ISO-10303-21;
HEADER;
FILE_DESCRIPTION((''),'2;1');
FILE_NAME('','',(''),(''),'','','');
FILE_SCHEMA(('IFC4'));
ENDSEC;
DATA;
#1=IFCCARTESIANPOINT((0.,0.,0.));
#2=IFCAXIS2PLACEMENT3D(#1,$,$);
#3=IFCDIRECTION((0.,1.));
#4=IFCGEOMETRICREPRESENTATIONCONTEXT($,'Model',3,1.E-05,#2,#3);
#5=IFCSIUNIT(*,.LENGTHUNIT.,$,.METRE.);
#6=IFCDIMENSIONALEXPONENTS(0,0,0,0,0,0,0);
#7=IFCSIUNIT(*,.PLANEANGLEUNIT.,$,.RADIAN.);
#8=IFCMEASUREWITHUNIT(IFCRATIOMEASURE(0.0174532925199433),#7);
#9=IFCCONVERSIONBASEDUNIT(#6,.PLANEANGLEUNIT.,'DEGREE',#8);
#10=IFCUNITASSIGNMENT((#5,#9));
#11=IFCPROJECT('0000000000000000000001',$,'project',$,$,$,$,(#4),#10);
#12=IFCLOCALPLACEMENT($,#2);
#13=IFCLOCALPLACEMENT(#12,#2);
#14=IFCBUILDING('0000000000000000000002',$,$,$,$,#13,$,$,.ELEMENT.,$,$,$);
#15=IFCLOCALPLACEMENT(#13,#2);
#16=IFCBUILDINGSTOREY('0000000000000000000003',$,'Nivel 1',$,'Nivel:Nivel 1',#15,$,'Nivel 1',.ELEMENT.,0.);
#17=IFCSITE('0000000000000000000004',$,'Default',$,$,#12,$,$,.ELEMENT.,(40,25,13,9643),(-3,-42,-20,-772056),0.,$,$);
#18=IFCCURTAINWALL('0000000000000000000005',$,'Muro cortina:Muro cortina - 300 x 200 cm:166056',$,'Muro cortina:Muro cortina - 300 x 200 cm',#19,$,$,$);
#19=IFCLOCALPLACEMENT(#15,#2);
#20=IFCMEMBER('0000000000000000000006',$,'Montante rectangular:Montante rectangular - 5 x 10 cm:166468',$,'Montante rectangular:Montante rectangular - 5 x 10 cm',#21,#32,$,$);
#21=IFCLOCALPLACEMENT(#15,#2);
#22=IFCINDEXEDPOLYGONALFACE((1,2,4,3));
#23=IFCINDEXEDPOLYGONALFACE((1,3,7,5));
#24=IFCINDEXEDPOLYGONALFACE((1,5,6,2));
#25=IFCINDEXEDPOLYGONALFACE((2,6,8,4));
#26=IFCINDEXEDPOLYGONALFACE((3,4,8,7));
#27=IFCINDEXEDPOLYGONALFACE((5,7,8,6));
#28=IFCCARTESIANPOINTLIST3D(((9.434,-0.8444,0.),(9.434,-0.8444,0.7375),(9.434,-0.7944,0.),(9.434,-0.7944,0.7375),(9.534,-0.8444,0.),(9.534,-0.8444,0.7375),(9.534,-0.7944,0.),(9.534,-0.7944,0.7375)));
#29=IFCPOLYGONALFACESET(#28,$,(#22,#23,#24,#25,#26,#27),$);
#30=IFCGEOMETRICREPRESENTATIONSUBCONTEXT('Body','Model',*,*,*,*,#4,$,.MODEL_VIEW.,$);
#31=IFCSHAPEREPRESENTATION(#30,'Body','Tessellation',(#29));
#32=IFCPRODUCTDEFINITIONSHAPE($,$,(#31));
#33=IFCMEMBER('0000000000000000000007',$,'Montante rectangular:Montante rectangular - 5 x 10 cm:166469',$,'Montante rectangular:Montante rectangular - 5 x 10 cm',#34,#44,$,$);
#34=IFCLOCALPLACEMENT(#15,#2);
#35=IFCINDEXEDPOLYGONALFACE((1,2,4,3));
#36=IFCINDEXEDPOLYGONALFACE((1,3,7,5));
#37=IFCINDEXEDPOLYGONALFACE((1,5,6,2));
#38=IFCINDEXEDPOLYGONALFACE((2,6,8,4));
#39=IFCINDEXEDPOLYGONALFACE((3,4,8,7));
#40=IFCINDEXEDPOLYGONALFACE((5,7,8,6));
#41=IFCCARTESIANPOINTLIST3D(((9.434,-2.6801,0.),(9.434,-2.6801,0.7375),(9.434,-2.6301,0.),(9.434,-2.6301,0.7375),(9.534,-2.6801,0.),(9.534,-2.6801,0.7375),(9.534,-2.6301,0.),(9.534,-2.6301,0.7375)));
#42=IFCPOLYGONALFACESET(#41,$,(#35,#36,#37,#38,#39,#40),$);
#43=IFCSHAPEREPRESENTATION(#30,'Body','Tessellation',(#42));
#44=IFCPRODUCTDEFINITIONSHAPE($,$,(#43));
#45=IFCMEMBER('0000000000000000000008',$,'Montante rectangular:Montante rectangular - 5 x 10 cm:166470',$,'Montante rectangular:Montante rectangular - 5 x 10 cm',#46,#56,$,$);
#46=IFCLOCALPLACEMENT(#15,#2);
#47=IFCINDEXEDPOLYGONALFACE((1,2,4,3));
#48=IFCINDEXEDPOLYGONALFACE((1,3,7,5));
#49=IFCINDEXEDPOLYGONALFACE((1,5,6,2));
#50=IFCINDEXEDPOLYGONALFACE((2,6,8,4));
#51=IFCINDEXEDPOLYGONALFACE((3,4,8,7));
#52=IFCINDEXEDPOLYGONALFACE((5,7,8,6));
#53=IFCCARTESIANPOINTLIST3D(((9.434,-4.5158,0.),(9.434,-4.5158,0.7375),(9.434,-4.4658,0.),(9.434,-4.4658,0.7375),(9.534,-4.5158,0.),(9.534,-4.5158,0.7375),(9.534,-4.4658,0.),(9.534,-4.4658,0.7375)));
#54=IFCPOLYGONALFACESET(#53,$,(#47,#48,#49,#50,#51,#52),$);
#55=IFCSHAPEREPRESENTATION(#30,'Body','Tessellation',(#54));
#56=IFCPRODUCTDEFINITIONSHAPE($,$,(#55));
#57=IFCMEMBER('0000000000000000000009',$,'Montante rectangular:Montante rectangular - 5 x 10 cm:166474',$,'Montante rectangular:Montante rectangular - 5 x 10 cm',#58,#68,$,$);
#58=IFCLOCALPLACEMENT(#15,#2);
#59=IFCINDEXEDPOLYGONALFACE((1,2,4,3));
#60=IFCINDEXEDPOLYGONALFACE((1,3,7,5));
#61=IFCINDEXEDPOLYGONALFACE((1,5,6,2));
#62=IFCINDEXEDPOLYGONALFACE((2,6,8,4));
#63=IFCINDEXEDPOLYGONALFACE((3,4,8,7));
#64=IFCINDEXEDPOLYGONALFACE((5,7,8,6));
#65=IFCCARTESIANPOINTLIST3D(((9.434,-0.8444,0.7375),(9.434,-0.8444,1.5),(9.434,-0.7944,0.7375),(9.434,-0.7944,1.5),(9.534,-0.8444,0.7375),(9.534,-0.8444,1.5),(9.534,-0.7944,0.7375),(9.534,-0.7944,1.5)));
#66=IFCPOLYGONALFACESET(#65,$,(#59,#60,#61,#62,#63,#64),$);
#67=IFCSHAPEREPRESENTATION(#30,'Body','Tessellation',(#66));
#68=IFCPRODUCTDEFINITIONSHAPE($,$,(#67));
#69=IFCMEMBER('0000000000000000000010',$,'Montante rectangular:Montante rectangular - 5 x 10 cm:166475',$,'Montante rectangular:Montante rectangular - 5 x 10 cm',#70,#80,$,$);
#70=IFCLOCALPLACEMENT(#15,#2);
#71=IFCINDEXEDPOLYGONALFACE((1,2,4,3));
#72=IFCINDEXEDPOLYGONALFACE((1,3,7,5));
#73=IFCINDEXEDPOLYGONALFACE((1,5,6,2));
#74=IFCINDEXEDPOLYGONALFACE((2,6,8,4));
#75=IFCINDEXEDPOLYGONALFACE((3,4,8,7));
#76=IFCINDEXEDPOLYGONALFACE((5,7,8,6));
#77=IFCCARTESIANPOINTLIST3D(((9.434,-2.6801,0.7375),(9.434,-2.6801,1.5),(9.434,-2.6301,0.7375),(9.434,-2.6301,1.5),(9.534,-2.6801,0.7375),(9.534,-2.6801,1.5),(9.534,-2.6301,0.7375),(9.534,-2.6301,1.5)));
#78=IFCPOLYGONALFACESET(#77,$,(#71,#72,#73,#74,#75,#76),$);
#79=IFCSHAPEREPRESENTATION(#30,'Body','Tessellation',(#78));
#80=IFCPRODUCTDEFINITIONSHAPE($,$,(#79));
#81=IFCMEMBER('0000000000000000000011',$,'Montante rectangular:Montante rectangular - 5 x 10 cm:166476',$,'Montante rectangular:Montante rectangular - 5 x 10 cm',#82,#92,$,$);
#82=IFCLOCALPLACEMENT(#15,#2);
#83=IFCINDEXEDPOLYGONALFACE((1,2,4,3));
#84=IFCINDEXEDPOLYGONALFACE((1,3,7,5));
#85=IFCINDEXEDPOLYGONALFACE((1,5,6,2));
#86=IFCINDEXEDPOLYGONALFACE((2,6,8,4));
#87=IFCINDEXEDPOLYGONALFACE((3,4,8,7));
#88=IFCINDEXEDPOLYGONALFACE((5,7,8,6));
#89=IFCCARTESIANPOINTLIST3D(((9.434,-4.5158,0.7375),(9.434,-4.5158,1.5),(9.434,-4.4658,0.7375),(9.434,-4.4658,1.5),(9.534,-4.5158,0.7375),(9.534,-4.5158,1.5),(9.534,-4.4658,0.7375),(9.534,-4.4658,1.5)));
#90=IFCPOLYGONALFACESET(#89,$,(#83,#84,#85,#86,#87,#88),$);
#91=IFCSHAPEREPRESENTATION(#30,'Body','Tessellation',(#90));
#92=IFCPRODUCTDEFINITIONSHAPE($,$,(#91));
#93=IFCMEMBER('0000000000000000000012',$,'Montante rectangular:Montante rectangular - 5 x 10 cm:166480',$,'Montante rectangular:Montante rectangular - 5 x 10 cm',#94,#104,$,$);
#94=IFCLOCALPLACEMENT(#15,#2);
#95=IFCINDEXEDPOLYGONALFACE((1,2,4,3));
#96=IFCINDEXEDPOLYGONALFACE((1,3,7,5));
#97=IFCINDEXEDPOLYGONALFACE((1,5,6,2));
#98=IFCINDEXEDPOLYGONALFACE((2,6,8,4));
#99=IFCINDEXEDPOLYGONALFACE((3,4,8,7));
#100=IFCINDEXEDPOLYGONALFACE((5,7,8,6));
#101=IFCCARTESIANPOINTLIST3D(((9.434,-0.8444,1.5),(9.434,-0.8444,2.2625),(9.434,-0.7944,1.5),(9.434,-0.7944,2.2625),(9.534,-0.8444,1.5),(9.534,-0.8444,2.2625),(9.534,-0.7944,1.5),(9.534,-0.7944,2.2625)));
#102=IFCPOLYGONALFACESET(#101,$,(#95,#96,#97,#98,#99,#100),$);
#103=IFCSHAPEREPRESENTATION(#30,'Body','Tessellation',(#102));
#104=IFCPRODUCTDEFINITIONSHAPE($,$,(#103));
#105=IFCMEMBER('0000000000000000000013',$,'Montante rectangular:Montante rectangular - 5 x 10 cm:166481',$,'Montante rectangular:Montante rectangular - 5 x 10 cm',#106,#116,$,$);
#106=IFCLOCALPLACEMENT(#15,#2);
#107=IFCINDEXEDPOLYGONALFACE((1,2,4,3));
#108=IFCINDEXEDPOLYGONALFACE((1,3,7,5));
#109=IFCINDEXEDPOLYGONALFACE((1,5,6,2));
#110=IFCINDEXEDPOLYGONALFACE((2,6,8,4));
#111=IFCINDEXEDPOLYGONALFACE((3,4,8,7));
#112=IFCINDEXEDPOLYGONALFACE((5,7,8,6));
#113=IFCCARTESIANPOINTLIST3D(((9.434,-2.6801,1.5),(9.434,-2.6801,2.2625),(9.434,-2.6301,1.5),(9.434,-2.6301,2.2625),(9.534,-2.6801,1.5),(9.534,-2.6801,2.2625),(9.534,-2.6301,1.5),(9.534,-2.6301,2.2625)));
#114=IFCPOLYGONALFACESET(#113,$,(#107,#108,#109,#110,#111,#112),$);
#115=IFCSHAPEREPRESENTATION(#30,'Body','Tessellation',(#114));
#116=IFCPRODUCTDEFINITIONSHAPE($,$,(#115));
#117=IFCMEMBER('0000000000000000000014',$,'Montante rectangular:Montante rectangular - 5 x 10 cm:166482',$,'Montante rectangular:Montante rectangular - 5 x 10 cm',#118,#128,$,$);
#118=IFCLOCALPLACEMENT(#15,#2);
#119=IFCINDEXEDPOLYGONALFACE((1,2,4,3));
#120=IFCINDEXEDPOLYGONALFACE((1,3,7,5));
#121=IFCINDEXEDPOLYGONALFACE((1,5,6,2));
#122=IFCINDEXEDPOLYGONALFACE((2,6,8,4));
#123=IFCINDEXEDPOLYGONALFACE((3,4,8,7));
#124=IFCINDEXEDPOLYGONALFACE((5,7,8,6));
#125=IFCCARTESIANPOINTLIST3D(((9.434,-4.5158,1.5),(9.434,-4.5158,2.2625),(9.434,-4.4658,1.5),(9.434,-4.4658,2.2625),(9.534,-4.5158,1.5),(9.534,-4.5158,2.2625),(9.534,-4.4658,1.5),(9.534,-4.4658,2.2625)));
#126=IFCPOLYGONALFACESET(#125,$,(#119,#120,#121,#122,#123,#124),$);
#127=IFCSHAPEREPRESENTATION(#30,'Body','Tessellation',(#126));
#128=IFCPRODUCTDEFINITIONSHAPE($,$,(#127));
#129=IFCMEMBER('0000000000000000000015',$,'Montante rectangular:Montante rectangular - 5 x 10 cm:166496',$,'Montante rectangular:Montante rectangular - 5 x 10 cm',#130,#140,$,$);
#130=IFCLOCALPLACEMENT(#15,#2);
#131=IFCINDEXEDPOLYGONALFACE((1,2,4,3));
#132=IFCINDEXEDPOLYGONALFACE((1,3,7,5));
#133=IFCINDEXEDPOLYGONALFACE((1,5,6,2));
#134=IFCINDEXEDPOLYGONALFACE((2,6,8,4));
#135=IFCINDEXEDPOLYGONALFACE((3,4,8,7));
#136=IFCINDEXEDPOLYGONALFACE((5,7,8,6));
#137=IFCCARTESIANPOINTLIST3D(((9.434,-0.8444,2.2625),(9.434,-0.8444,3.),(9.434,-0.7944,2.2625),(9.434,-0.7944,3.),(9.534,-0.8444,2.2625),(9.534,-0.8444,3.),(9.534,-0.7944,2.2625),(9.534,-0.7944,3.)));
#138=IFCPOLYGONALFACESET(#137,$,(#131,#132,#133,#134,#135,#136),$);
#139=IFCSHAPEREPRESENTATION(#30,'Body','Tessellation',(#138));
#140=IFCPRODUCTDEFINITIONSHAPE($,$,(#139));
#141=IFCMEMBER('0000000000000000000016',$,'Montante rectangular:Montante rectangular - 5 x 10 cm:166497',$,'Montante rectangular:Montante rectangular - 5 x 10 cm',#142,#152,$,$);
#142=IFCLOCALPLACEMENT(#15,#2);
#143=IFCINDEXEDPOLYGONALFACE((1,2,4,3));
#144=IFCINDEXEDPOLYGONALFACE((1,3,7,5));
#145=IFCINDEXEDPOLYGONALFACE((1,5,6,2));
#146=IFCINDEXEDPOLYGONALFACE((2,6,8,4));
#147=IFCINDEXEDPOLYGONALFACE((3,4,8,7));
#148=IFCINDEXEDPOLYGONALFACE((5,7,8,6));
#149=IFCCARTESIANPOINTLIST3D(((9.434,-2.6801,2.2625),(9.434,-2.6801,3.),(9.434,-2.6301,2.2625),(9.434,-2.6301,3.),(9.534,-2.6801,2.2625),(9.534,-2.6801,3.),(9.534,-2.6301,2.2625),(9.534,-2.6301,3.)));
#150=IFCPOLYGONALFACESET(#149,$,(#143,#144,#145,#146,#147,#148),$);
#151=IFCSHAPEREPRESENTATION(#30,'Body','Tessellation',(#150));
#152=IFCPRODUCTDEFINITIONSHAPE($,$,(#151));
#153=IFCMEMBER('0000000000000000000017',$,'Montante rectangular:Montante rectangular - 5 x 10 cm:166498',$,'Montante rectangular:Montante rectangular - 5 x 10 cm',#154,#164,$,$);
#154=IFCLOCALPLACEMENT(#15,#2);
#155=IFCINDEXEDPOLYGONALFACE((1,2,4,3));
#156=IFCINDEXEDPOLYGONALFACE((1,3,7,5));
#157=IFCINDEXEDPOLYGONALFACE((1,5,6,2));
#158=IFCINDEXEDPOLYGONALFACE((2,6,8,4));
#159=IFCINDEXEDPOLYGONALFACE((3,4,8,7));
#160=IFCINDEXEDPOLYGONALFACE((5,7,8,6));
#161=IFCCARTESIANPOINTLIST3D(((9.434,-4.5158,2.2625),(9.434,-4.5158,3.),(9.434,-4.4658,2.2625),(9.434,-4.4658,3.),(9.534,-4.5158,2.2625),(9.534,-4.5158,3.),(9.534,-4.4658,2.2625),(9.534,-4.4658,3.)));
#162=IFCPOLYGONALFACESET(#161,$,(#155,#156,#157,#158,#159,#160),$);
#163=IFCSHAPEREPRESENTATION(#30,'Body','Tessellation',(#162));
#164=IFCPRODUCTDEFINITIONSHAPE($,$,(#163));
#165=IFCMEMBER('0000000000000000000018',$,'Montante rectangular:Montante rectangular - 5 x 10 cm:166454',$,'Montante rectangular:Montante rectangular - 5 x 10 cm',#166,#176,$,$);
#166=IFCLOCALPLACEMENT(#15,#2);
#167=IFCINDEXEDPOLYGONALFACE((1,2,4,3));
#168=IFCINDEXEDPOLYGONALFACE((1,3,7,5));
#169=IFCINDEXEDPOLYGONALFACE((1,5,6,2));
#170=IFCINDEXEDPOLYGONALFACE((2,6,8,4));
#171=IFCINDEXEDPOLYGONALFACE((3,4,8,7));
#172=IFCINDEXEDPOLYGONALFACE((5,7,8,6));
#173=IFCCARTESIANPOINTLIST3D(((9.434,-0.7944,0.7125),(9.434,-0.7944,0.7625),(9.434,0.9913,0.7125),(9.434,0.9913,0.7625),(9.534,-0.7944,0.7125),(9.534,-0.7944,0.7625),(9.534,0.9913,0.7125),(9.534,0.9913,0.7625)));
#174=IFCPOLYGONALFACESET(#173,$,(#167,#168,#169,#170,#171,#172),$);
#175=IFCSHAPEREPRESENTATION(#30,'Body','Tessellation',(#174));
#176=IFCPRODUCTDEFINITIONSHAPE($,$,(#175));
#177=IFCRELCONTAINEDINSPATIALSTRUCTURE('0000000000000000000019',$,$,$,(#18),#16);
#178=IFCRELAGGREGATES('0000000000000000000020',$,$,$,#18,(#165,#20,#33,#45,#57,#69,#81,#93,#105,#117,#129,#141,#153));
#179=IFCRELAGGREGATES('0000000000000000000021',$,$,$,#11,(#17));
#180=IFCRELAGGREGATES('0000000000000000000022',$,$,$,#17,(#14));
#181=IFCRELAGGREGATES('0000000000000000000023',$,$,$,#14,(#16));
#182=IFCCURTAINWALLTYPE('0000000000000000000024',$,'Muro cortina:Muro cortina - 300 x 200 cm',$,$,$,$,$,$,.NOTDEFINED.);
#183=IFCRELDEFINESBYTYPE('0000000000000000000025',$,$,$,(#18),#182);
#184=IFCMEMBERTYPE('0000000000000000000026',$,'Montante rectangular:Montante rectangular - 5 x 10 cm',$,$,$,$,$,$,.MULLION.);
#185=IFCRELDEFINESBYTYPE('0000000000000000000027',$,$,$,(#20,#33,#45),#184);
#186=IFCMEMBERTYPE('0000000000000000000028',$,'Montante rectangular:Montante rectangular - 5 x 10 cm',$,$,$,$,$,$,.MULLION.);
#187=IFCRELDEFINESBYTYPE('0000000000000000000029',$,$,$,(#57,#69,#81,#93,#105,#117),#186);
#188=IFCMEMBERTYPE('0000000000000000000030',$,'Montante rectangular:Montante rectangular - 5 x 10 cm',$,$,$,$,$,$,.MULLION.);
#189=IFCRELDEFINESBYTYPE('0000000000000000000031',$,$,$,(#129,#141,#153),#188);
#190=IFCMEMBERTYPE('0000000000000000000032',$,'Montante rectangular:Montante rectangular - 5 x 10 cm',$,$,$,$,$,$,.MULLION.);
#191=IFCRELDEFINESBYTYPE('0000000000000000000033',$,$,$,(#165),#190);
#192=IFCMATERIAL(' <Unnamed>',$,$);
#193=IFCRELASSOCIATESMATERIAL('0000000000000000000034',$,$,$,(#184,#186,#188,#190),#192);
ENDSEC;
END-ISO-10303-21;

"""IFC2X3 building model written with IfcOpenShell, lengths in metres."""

from ifc_helpers import new_model, entity, si_unit, converted_unit, direction, frame, origin, origin_2d_with_axis, place, context, subcontext, project, spatial, rectangle, extrude, source, transform, mapped, material, type_object, type_shapes, element, aggregate, save


model = new_model("IFC2X3")

# Units and contexts
model_context = context("Model", 3, precision=1e-05, world=origin(), true_north=direction((0.0, 1.0)))
body_context = subcontext(model_context, "Body", "Model", "MODEL_VIEW")
ifc_project = project(units=[si_unit("LENGTHUNIT", "METRE"), converted_unit("PLANEANGLEUNIT", "DEGREE", entity("IfcRatioMeasure", 0.0174532925199433), si_unit("PLANEANGLEUNIT", "RADIAN"), dimensions=[0, 0, 0, 0, 0, 0, 0])], contexts=[model_context])

# Site, building, storey
site_placement = place(None, origin())
site = spatial("IfcSite", under=ifc_project, at=site_placement, Name="Default", CompositionType="ELEMENT", RefLatitude=(40, 25, 13, 9643), RefLongitude=(-3, -42, -20, -772056), RefElevation=0.0)
building_placement = place(site_placement, origin())
building = spatial("IfcBuilding", under=site, at=building_placement, CompositionType="ELEMENT")
storey_placement = place(building_placement, origin())
storey = spatial("IfcBuildingStorey", under=building, at=storey_placement, Name="Nivel 1", ObjectType="Nivel:Nivel 1", LongName="Nivel 1", CompositionType="ELEMENT", Elevation=0.0)

# Curtain wall, members
curtain_wall_type = type_object("IfcCurtainWallType", Name="Muro cortina:Muro cortina - 300 x 200 cm", PredefinedType="NOTDEFINED")
curtain_wall_placement = place(storey_placement, origin())
curtain_wall = element("IfcCurtainWall", 1, at=curtain_wall_placement, inside=storey, type_object=curtain_wall_type, Name="Muro cortina:Muro cortina - 300 x 200 cm:166056", ObjectType="Muro cortina:Muro cortina - 300 x 200 cm")
ifc_material_1 = material(Name=" <Unnamed>")
member_type_1 = type_object("IfcMemberType", Name="Montante rectangular:Montante rectangular - 5 x 10 cm", PredefinedType="MULLION", material=ifc_material_1)
shared_shape_1 = source(origin(), body_context, "Body", "SweptSolid", [
    extrude(rectangle(XDim=0.1, YDim=0.05, at=origin_2d_with_axis()), frame((0.0, 0.0, -0.7375), z_axis=(0.0, 0.0, 1.0), x_axis=(0.0, -1.0, 0.0)), (0.0, 0.0, 1.0), 0.7375),
])
type_shapes(member_type_1, [shared_shape_1])
member_1_placement = place(storey_placement, frame((9.484, -0.8194, 0.0), z_axis=(0.0, 0.0, -1.0), x_axis=(0.0, -1.0, 0.0)))
member_1 = element("IfcMember", 2, at=member_1_placement, type_object=member_type_1, Name="Montante rectangular:Montante rectangular - 5 x 10 cm:166468", ObjectType="Montante rectangular:Montante rectangular - 5 x 10 cm", context=body_context, shape_type="MappedRepresentation", body=[
    mapped(shared_shape_1, transform((0.0, 0.0, 0.0), scale=1.0)),
])
member_2_placement = place(storey_placement, frame((9.484, -2.6551, 0.0), z_axis=(0.0, 0.0, -1.0), x_axis=(0.0, -1.0, 0.0)))
member_2 = element("IfcMember", 3, at=member_2_placement, type_object=member_type_1, Name="Montante rectangular:Montante rectangular - 5 x 10 cm:166469", ObjectType="Montante rectangular:Montante rectangular - 5 x 10 cm", context=body_context, shape_type="MappedRepresentation", body=[
    mapped(shared_shape_1, transform((0.0, 0.0, 0.0), scale=1.0)),
])
member_3_placement = place(storey_placement, frame((9.484, -4.4908, 0.0), z_axis=(0.0, 0.0, -1.0), x_axis=(0.0, -1.0, 0.0)))
member_3 = element("IfcMember", 4, at=member_3_placement, type_object=member_type_1, Name="Montante rectangular:Montante rectangular - 5 x 10 cm:166470", ObjectType="Montante rectangular:Montante rectangular - 5 x 10 cm", context=body_context, shape_type="MappedRepresentation", body=[
    mapped(shared_shape_1, transform((0.0, 0.0, 0.0), scale=1.0)),
])
member_type_2 = type_object("IfcMemberType", Name="Montante rectangular:Montante rectangular - 5 x 10 cm", PredefinedType="MULLION", material=ifc_material_1)
shared_shape_2 = source(origin(), body_context, "Body", "SweptSolid", [
    extrude(rectangle(XDim=0.1, YDim=0.05, at=origin_2d_with_axis()), frame((0.0, 0.0, -0.7625), z_axis=(0.0, 0.0, 1.0), x_axis=(0.0, -1.0, 0.0)), (0.0, 0.0, 1.0), 0.7625),
])
type_shapes(member_type_2, [shared_shape_2])
member_4_placement = place(storey_placement, frame((9.484, -0.8194, 0.7375), z_axis=(0.0, 0.0, -1.0), x_axis=(0.0, -1.0, 0.0)))
member_4 = element("IfcMember", 5, at=member_4_placement, type_object=member_type_2, Name="Montante rectangular:Montante rectangular - 5 x 10 cm:166474", ObjectType="Montante rectangular:Montante rectangular - 5 x 10 cm", context=body_context, shape_type="MappedRepresentation", body=[
    mapped(shared_shape_2, transform((0.0, 0.0, 0.0), scale=1.0)),
])
member_5_placement = place(storey_placement, frame((9.484, -2.6551, 0.7375), z_axis=(0.0, 0.0, -1.0), x_axis=(0.0, -1.0, 0.0)))
member_5 = element("IfcMember", 6, at=member_5_placement, type_object=member_type_2, Name="Montante rectangular:Montante rectangular - 5 x 10 cm:166475", ObjectType="Montante rectangular:Montante rectangular - 5 x 10 cm", context=body_context, shape_type="MappedRepresentation", body=[
    mapped(shared_shape_2, transform((0.0, 0.0, 0.0), scale=1.0)),
])
member_6_placement = place(storey_placement, frame((9.484, -4.4908, 0.7375), z_axis=(0.0, 0.0, -1.0), x_axis=(0.0, -1.0, 0.0)))
member_6 = element("IfcMember", 7, at=member_6_placement, type_object=member_type_2, Name="Montante rectangular:Montante rectangular - 5 x 10 cm:166476", ObjectType="Montante rectangular:Montante rectangular - 5 x 10 cm", context=body_context, shape_type="MappedRepresentation", body=[
    mapped(shared_shape_2, transform((0.0, 0.0, 0.0), scale=1.0)),
])
member_7_placement = place(storey_placement, frame((9.484, -0.8194, 1.5), z_axis=(0.0, 0.0, -1.0), x_axis=(0.0, -1.0, 0.0)))
member_7 = element("IfcMember", 8, at=member_7_placement, type_object=member_type_2, Name="Montante rectangular:Montante rectangular - 5 x 10 cm:166480", ObjectType="Montante rectangular:Montante rectangular - 5 x 10 cm", context=body_context, shape_type="MappedRepresentation", body=[
    mapped(shared_shape_2, transform((0.0, 0.0, 0.0), scale=1.0)),
])
member_8_placement = place(storey_placement, frame((9.484, -2.6551, 1.5), z_axis=(0.0, 0.0, -1.0), x_axis=(0.0, -1.0, 0.0)))
member_8 = element("IfcMember", 9, at=member_8_placement, type_object=member_type_2, Name="Montante rectangular:Montante rectangular - 5 x 10 cm:166481", ObjectType="Montante rectangular:Montante rectangular - 5 x 10 cm", context=body_context, shape_type="MappedRepresentation", body=[
    mapped(shared_shape_2, transform((0.0, 0.0, 0.0), scale=1.0)),
])
member_9_placement = place(storey_placement, frame((9.484, -4.4908, 1.5), z_axis=(0.0, 0.0, -1.0), x_axis=(0.0, -1.0, 0.0)))
member_9 = element("IfcMember", 10, at=member_9_placement, type_object=member_type_2, Name="Montante rectangular:Montante rectangular - 5 x 10 cm:166482", ObjectType="Montante rectangular:Montante rectangular - 5 x 10 cm", context=body_context, shape_type="MappedRepresentation", body=[
    mapped(shared_shape_2, transform((0.0, 0.0, 0.0), scale=1.0)),
])
member_type_3 = type_object("IfcMemberType", Name="Montante rectangular:Montante rectangular - 5 x 10 cm", PredefinedType="MULLION", material=ifc_material_1)
shared_shape_3 = source(origin(), body_context, "Body", "SweptSolid", [
    extrude(rectangle(XDim=0.1, YDim=0.05, at=origin_2d_with_axis()), frame((0.0, 0.0, -0.7375), z_axis=(0.0, 0.0, 1.0), x_axis=(0.0, -1.0, 0.0)), (0.0, 0.0, 1.0), 0.7375),
])
type_shapes(member_type_3, [shared_shape_3])
member_10_placement = place(storey_placement, frame((9.484, -0.8194, 2.2625), z_axis=(0.0, 0.0, -1.0), x_axis=(0.0, -1.0, 0.0)))
member_10 = element("IfcMember", 11, at=member_10_placement, type_object=member_type_3, Name="Montante rectangular:Montante rectangular - 5 x 10 cm:166496", ObjectType="Montante rectangular:Montante rectangular - 5 x 10 cm", context=body_context, shape_type="MappedRepresentation", body=[
    mapped(shared_shape_3, transform((0.0, 0.0, 0.0), scale=1.0)),
])
member_11_placement = place(storey_placement, frame((9.484, -2.6551, 2.2625), z_axis=(0.0, 0.0, -1.0), x_axis=(0.0, -1.0, 0.0)))
member_11 = element("IfcMember", 12, at=member_11_placement, type_object=member_type_3, Name="Montante rectangular:Montante rectangular - 5 x 10 cm:166497", ObjectType="Montante rectangular:Montante rectangular - 5 x 10 cm", context=body_context, shape_type="MappedRepresentation", body=[
    mapped(shared_shape_3, transform((0.0, 0.0, 0.0), scale=1.0)),
])
member_12_placement = place(storey_placement, frame((9.484, -4.4908, 2.2625), z_axis=(0.0, 0.0, -1.0), x_axis=(0.0, -1.0, 0.0)))
member_12 = element("IfcMember", 13, at=member_12_placement, type_object=member_type_3, Name="Montante rectangular:Montante rectangular - 5 x 10 cm:166498", ObjectType="Montante rectangular:Montante rectangular - 5 x 10 cm", context=body_context, shape_type="MappedRepresentation", body=[
    mapped(shared_shape_3, transform((0.0, 0.0, 0.0), scale=1.0)),
])
member_type_4 = type_object("IfcMemberType", Name="Montante rectangular:Montante rectangular - 5 x 10 cm", PredefinedType="MULLION", material=ifc_material_1)
shared_shape_4 = source(origin(), body_context, "Body", "SweptSolid", [
    extrude(rectangle(XDim=0.1, YDim=0.05, at=origin_2d_with_axis()), frame((0.0, 0.0, -1.7857), z_axis=(0.0, 0.0, 1.0), x_axis=(0.0, -1.0, 0.0)), (0.0, 0.0, 1.0), 1.7857),
])
type_shapes(member_type_4, [shared_shape_4])
member_13_placement = place(storey_placement, frame((9.484, -0.7944, 0.7375), z_axis=(0.0, -1.0, 0.0), x_axis=(0.0, 0.0, 1.0)))
member_13 = element("IfcMember", 14, at=member_13_placement, type_object=member_type_4, Name="Montante rectangular:Montante rectangular - 5 x 10 cm:166454", ObjectType="Montante rectangular:Montante rectangular - 5 x 10 cm", context=body_context, shape_type="MappedRepresentation", body=[
    mapped(shared_shape_4, transform((0.0, 0.0, 0.0), scale=1.0)),
])
aggregate(curtain_wall, [member_13, member_1, member_2, member_3, member_4, member_5, member_6, member_7, member_8, member_9, member_10, member_11, member_12])

save(model, "model.ifc")
